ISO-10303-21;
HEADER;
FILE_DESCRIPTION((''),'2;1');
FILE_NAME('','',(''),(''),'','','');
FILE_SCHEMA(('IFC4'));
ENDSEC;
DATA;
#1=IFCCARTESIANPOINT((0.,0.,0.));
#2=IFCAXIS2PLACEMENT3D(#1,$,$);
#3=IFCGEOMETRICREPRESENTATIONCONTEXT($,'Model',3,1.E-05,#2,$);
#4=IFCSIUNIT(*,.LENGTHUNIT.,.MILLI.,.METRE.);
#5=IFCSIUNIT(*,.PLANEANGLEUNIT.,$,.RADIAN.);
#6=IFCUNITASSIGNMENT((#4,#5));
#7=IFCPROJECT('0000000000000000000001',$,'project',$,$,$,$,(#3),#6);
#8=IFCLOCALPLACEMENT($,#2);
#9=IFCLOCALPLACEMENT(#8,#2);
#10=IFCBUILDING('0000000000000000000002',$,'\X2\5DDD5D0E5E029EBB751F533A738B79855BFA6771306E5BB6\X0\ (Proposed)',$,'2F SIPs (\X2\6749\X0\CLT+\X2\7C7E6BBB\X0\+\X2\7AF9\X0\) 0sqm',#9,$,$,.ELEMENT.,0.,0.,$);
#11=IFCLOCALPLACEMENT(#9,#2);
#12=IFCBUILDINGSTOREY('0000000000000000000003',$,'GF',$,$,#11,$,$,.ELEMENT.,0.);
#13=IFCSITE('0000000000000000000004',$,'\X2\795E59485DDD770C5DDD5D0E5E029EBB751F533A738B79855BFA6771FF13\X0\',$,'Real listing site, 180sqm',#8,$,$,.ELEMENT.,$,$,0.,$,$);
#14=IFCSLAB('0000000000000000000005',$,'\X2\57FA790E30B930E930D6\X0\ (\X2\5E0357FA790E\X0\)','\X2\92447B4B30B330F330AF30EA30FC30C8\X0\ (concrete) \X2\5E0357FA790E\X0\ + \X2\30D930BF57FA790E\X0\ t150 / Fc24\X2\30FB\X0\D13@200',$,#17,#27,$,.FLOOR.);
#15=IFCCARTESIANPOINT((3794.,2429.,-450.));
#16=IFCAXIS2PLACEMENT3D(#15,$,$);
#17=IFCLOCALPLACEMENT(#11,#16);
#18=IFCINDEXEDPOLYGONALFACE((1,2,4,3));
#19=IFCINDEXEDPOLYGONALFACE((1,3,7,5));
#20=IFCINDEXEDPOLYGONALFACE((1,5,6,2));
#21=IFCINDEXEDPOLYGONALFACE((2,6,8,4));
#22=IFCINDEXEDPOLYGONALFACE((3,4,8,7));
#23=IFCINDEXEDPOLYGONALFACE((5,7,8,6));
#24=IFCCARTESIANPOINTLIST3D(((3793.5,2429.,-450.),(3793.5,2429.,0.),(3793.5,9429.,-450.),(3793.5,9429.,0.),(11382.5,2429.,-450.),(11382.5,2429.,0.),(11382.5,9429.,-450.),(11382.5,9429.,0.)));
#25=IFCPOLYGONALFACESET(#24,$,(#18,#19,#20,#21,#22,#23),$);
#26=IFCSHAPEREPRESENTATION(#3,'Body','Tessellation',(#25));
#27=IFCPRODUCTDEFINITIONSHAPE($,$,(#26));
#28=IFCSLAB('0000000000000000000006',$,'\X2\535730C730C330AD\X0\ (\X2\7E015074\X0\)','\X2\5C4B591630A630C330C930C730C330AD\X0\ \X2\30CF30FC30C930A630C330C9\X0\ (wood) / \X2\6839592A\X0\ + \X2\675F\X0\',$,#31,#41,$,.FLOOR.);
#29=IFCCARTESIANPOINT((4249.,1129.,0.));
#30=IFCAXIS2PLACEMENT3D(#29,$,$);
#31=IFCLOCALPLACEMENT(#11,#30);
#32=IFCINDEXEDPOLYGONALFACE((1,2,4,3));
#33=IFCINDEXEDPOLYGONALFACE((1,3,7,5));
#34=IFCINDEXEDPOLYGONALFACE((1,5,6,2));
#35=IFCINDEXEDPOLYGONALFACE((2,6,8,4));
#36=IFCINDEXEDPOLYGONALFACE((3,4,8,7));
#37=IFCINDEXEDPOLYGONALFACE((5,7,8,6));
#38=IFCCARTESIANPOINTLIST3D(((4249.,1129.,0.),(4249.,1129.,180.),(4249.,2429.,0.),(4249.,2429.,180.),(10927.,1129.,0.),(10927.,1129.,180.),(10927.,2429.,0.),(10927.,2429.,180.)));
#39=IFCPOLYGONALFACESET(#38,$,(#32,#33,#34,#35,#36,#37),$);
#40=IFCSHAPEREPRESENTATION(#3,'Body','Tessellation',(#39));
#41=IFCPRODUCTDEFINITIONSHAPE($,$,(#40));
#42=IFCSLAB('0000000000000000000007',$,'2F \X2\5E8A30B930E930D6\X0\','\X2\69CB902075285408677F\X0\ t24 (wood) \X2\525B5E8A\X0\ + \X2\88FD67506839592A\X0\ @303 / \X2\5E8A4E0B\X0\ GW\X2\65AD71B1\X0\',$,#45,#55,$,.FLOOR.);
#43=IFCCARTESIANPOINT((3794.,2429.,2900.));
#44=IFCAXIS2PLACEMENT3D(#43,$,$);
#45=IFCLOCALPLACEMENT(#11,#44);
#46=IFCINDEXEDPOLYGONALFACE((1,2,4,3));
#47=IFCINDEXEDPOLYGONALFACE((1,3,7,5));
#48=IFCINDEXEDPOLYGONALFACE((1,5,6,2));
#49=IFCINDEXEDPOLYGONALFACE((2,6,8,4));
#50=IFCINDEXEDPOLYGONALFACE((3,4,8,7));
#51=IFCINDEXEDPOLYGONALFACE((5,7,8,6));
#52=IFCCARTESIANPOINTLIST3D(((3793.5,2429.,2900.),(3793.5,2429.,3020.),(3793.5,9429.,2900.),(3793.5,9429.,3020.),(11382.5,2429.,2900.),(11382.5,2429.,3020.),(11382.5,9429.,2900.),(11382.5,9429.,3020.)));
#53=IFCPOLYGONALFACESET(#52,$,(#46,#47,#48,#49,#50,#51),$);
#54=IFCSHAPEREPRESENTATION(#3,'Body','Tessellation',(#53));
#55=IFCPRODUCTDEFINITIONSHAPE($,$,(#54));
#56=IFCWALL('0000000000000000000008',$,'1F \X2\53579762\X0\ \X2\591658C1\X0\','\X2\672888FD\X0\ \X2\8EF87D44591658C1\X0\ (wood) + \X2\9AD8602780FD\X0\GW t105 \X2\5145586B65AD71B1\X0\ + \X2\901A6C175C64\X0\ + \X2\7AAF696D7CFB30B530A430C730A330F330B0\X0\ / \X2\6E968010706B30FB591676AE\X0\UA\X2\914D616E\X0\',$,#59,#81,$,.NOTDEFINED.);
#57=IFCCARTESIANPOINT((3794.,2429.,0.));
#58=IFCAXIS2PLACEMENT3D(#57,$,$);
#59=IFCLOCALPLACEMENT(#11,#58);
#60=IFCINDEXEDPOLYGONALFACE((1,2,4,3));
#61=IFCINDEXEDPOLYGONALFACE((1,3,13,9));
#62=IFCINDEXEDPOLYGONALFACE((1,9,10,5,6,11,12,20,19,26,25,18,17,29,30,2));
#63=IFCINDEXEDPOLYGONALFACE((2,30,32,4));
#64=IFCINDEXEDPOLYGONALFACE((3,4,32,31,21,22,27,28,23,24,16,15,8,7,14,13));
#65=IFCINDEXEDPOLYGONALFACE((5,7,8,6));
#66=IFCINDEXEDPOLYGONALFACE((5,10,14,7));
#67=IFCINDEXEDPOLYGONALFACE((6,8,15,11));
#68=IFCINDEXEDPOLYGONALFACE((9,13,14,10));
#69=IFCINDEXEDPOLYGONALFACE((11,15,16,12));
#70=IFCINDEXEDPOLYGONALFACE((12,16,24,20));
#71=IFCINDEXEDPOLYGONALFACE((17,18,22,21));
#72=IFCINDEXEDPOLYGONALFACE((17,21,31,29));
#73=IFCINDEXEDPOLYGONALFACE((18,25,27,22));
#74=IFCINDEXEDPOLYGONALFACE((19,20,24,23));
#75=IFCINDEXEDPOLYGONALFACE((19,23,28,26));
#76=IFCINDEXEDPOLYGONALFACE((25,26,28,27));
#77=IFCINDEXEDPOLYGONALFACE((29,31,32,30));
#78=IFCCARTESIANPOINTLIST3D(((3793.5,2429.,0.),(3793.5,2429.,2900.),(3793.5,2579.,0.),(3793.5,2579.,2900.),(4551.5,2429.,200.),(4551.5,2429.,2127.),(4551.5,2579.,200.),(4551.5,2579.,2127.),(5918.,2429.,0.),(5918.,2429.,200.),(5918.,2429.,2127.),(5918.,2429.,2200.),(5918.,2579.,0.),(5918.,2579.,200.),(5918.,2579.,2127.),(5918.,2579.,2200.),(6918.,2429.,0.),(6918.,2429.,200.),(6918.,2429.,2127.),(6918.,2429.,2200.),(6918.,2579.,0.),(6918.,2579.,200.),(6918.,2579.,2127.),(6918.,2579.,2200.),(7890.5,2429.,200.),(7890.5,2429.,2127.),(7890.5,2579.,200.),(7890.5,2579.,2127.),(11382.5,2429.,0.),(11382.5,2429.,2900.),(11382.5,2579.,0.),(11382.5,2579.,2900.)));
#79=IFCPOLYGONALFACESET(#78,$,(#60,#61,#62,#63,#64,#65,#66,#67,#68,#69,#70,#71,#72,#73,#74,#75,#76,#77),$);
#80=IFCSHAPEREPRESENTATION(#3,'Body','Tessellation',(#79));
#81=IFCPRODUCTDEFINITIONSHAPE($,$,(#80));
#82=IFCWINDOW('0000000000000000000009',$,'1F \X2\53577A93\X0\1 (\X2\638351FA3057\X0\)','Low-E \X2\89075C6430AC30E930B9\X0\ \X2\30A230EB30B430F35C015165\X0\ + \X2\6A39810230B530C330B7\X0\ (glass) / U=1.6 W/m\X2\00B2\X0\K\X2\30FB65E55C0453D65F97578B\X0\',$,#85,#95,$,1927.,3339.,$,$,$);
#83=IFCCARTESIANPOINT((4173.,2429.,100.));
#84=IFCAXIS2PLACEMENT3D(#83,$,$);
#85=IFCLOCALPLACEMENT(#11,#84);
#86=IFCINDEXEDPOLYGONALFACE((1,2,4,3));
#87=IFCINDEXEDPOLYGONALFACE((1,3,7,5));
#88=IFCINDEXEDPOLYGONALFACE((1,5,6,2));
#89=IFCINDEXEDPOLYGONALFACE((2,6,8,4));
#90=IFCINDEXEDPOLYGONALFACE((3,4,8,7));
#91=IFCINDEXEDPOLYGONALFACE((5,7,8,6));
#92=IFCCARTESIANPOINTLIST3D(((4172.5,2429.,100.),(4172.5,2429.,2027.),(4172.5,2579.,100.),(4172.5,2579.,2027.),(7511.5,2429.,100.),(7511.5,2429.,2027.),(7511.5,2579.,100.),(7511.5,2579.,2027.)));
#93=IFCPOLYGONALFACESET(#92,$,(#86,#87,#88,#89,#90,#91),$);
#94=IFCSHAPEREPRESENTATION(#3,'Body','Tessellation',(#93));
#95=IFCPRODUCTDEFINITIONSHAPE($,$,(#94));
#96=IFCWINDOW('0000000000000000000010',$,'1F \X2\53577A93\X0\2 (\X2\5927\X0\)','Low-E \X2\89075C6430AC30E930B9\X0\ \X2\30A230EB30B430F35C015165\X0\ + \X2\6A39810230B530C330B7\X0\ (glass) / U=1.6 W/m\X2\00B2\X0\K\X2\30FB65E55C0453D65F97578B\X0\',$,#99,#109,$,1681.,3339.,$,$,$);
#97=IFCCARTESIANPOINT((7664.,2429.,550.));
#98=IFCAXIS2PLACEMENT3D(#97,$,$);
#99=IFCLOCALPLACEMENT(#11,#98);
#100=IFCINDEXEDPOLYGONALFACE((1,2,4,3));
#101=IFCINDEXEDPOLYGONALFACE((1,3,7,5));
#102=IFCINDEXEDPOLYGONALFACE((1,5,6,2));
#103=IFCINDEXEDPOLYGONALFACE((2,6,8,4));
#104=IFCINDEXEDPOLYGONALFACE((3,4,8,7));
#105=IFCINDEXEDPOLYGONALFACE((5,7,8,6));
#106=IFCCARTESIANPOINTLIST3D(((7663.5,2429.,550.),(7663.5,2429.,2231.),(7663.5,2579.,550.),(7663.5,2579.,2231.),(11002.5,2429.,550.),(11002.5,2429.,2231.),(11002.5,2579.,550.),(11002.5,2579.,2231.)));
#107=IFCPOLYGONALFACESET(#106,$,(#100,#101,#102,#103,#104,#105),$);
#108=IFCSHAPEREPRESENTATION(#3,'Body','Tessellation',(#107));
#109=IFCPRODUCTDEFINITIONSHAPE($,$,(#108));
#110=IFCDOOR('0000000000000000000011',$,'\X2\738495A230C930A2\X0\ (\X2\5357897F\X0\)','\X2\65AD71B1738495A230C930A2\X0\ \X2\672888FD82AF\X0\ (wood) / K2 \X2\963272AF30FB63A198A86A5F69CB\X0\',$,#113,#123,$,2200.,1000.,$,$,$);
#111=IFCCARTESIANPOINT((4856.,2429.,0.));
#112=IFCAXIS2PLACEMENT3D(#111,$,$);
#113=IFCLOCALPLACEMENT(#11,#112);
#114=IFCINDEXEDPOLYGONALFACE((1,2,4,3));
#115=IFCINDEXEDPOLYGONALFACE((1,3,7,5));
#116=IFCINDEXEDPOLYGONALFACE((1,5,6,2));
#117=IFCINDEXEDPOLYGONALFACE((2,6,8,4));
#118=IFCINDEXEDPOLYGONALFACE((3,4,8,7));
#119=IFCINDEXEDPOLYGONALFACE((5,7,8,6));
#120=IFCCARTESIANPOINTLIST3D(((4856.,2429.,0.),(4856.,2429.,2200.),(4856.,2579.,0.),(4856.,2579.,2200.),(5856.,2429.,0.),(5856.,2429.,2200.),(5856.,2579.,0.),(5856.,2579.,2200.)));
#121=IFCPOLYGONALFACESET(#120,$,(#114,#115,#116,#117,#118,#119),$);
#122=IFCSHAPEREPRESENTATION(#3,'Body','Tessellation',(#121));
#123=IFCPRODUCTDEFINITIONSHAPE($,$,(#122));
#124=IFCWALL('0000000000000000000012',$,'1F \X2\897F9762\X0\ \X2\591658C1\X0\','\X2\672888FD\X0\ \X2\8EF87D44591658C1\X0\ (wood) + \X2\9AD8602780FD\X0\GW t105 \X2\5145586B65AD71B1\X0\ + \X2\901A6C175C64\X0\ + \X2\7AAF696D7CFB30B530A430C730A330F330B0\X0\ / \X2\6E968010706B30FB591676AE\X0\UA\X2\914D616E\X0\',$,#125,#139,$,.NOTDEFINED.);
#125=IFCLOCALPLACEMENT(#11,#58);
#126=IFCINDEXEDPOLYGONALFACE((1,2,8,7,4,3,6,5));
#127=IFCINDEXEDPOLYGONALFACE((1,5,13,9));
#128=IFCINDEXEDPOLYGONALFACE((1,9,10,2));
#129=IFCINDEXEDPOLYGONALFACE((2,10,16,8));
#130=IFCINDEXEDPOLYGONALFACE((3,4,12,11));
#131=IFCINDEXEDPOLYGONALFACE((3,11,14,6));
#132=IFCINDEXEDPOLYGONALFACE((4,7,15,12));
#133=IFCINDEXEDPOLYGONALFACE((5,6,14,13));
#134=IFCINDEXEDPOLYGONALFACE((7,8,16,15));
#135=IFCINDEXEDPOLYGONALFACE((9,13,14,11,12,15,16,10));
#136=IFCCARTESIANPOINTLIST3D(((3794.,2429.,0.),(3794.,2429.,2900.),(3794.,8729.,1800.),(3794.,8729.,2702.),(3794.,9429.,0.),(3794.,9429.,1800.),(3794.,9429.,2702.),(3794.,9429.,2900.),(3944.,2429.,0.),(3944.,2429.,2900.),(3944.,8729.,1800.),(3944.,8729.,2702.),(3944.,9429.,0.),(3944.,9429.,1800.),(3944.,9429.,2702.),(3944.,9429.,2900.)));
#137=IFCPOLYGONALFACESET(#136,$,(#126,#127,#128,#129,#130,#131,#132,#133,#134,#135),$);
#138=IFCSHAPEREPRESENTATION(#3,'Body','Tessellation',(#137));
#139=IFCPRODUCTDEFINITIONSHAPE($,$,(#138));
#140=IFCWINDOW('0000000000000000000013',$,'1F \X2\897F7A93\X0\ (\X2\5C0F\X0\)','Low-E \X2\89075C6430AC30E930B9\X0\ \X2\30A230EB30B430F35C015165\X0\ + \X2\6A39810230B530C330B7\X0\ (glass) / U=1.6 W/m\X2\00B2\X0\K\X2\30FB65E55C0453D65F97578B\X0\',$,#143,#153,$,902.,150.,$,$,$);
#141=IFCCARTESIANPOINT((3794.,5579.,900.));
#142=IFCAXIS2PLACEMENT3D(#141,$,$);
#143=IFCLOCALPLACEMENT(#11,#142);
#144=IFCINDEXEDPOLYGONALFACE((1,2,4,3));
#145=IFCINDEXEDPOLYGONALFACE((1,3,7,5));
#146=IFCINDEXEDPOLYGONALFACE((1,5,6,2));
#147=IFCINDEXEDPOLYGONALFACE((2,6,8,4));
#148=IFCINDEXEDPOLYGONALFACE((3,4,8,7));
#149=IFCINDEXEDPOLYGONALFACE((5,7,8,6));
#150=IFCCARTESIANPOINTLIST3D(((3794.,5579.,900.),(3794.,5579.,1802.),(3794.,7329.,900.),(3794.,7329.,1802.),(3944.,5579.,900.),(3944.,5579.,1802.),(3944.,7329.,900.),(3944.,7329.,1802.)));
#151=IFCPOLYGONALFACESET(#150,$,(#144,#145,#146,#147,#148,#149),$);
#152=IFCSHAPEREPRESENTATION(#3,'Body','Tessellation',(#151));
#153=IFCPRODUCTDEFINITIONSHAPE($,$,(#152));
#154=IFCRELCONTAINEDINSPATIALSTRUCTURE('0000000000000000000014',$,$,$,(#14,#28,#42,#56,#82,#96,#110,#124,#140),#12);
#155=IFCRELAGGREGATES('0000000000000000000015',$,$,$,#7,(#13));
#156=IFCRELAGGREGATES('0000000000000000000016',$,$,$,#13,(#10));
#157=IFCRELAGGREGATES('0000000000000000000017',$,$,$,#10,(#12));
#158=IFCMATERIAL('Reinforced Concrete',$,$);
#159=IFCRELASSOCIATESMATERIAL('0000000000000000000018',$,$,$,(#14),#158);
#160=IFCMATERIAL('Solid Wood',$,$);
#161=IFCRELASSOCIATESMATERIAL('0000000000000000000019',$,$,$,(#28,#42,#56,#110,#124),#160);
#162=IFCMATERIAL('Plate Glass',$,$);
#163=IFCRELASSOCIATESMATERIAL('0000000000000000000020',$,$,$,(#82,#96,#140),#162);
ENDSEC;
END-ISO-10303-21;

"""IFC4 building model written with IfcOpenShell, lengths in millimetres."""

from ifc_helpers import new_model, si_unit, frame, frame_2d, origin, place, context, project, spatial, rectangle, extrude, material, element, fill, save


model = new_model("IFC4")

# Units and contexts
model_context = context("Model", 3, precision=1e-05, world=origin())
ifc_project = project(units=[si_unit("LENGTHUNIT", "METRE", prefix="MILLI"), si_unit("PLANEANGLEUNIT", "RADIAN")], contexts=[model_context])

# Site, building, storey
site_placement = place(None, origin())
site = spatial("IfcSite", under=ifc_project, at=site_placement, Name="神奈川県川崎市麻生区王禅寺東３", ObjectType="Real listing site, 180sqm", CompositionType="ELEMENT", RefElevation=0.0)
building_placement = place(site_placement, origin())
building = spatial("IfcBuilding", under=site, at=building_placement, Name="川崎市麻生区王禅寺東の家 (Proposed)", ObjectType="2F SIPs (杉CLT+籾殻+竹) 0sqm", CompositionType="ELEMENT", ElevationOfRefHeight=0.0, ElevationOfTerrain=0.0)
storey_placement = place(building_placement, origin())
storey = spatial("IfcBuildingStorey", under=building, at=storey_placement, Name="GF", CompositionType="ELEMENT", Elevation=0.0)

# Slabs
ifc_material_1 = material(Name="Reinforced Concrete")
slab_1_placement = place(storey_placement, frame((3794.0, 2429.0, -450.0)))
element("IfcSlab", 1, at=slab_1_placement, inside=storey, material=ifc_material_1, Name="基礎スラブ (布基礎)", Description="鉄筋コンクリート (concrete) 布基礎 + ベタ基礎 t150 / Fc24・D13@200", PredefinedType="FLOOR", context=model_context, shape_type="SweptSolid", body=[
    extrude(rectangle(XDim=7589.0, YDim=7000.0, at=frame_2d((3794.0, 3500.0))), frame((3794.0, 2429.0, -450.0)), (0.0, 0.0, 1.0), 450.0),
])
ifc_material_2 = material(Name="Solid Wood")
slab_2_placement = place(storey_placement, frame((4249.0, 1129.0, 0.0)))
element("IfcSlab", 2, at=slab_2_placement, inside=storey, material=ifc_material_2, Name="南デッキ (縁側)", Description="屋外ウッドデッキ ハードウッド (wood) / 根太 + 束", PredefinedType="FLOOR", context=model_context, shape_type="SweptSolid", body=[
    extrude(rectangle(XDim=6678.0, YDim=1300.0, at=frame_2d((3339.0, 650.0))), frame((4249.0, 1129.0, 0.0)), (0.0, 0.0, 1.0), 180.0),
])
slab_3_placement = place(storey_placement, frame((3794.0, 2429.0, 2900.0)))
element("IfcSlab", 3, at=slab_3_placement, inside=storey, material=ifc_material_2, Name="2F 床スラブ", Description="構造用合板 t24 (wood) 剛床 + 製材根太 @303 / 床下 GW断熱", PredefinedType="FLOOR", context=model_context, shape_type="SweptSolid", body=[
    extrude(rectangle(XDim=7589.0, YDim=7000.0, at=frame_2d((3794.0, 3500.0))), frame((3794.0, 2429.0, 2900.0)), (0.0, 0.0, 1.0), 120.0),
])

# Wall, openings, windows, door
wall_1_placement = place(storey_placement, frame((3794.0, 2429.0, 0.0)))
wall_1 = element("IfcWall", 4, at=wall_1_placement, inside=storey, material=ifc_material_2, Name="1F 南面 外壁", Description="木製 軸組外壁 (wood) + 高性能GW t105 充填断熱 + 通気層 + 窯業系サイディング / 準耐火・外皮UA配慮", PredefinedType="NOTDEFINED", context=model_context, shape_type="SweptSolid", body=[
    extrude(rectangle(XDim=7589.0, YDim=150.0, at=frame_2d((3794.0, 75.0))), frame((3794.0, 2429.0, 0.0)), (0.0, 0.0, 1.0), 2900.0),
])
opening_1_placement = place(storey_placement, frame((4173.0, 2429.0, 100.0)))
opening_1 = element("IfcOpeningElement", 5, at=opening_1_placement, cuts=wall_1, PredefinedType="NOTDEFINED", context=model_context, shape_type="SweptSolid", body=[
    extrude(rectangle(XDim=3339.0, YDim=150.0, at=frame_2d((1669.0, 75.0))), frame((4173.0, 2429.0, 100.0)), (0.0, 0.0, 1.0), 1927.0),
])
opening_2_placement = place(storey_placement, frame((7664.0, 2429.0, 550.0)))
opening_2 = element("IfcOpeningElement", 6, at=opening_2_placement, cuts=wall_1, PredefinedType="NOTDEFINED", context=model_context, shape_type="SweptSolid", body=[
    extrude(rectangle(XDim=3339.0, YDim=150.0, at=frame_2d((1669.0, 75.0))), frame((7664.0, 2429.0, 550.0)), (0.0, 0.0, 1.0), 1681.0),
])
opening_3_placement = place(storey_placement, frame((4856.0, 2429.0, 0.0)))
opening_3 = element("IfcOpeningElement", 7, at=opening_3_placement, cuts=wall_1, PredefinedType="NOTDEFINED", context=model_context, shape_type="SweptSolid", body=[
    extrude(rectangle(XDim=1000.0, YDim=150.0, at=frame_2d((500.0, 75.0))), frame((4856.0, 2429.0, 0.0)), (0.0, 0.0, 1.0), 2200.0),
])
ifc_material_3 = material(Name="Plate Glass")
window_1_placement = place(storey_placement, frame((4173.0, 2429.0, 100.0)))
window_1 = element("IfcWindow", 8, at=window_1_placement, inside=storey, material=ifc_material_3, Name="1F 南窓1 (掃出し)", Description="Low-E 複層ガラス アルゴン封入 + 樹脂サッシ (glass) / U=1.6 W/m²K・日射取得型", OverallHeight=1927.0, OverallWidth=3339.0, context=model_context, shape_type="SweptSolid", body=[
    extrude(rectangle(XDim=3339.0, YDim=150.0, at=frame_2d((1669.0, 75.0))), frame((4173.0, 2429.0, 100.0)), (0.0, 0.0, 1.0), 1927.0),
])
fill(opening_1, window_1)
window_2_placement = place(storey_placement, frame((7664.0, 2429.0, 550.0)))
window_2 = element("IfcWindow", 9, at=window_2_placement, inside=storey, material=ifc_material_3, Name="1F 南窓2 (大)", Description="Low-E 複層ガラス アルゴン封入 + 樹脂サッシ (glass) / U=1.6 W/m²K・日射取得型", OverallHeight=1681.0, OverallWidth=3339.0, context=model_context, shape_type="SweptSolid", body=[
    extrude(rectangle(XDim=3339.0, YDim=150.0, at=frame_2d((1669.0, 75.0))), frame((7664.0, 2429.0, 550.0)), (0.0, 0.0, 1.0), 1681.0),
])
fill(opening_2, window_2)
door_placement = place(storey_placement, frame((4856.0, 2429.0, 0.0)))
door = element("IfcDoor", 10, at=door_placement, inside=storey, material=ifc_material_2, Name="玄関ドア (南西)", Description="断熱玄関ドア 木製芯 (wood) / K2 防犯・採風機構", OverallHeight=2200.0, OverallWidth=1000.0, context=model_context, shape_type="SweptSolid", body=[
    extrude(rectangle(XDim=1000.0, YDim=150.0, at=frame_2d((500.0, 75.0))), frame((4856.0, 2429.0, 0.0)), (0.0, 0.0, 1.0), 2200.0),
])
fill(opening_3, door)

# Wall, opening, window
wall_2_placement = place(storey_placement, frame((3794.0, 2429.0, 0.0)))
wall_2 = element("IfcWall", 11, at=wall_2_placement, inside=storey, material=ifc_material_2, Name="1F 西面 外壁", Description="木製 軸組外壁 (wood) + 高性能GW t105 充填断熱 + 通気層 + 窯業系サイディング / 準耐火・外皮UA配慮", PredefinedType="NOTDEFINED", context=model_context, shape_type="SweptSolid", body=[
    extrude(rectangle(XDim=150.0, YDim=7000.0, at=frame_2d((75.0, 3500.0))), frame((3794.0, 2429.0, 0.0)), (0.0, 0.0, 1.0), 2900.0),
])
opening_4_placement = place(storey_placement, frame((3794.0, 5579.0, 900.0)))
opening_4 = element("IfcOpeningElement", 12, at=opening_4_placement, cuts=wall_2, PredefinedType="NOTDEFINED", context=model_context, shape_type="SweptSolid", body=[
    extrude(rectangle(XDim=150.0, YDim=1750.0, at=frame_2d((75.0, 875.0))), frame((3794.0, 5579.0, 900.0)), (0.0, 0.0, 1.0), 902.0),
])
window_3_placement = place(storey_placement, frame((3794.0, 5579.0, 900.0)))
window_3 = element("IfcWindow", 13, at=window_3_placement, inside=storey, material=ifc_material_3, Name="1F 西窓 (小)", Description="Low-E 複層ガラス アルゴン封入 + 樹脂サッシ (glass) / U=1.6 W/m²K・日射取得型", OverallHeight=902.0, OverallWidth=150.0, context=model_context, shape_type="SweptSolid", body=[
    extrude(rectangle(XDim=150.0, YDim=1750.0, at=frame_2d((75.0, 875.0))), frame((3794.0, 5579.0, 900.0)), (0.0, 0.0, 1.0), 902.0),
])
fill(opening_4, window_3)

save(model, "model.ifc")
